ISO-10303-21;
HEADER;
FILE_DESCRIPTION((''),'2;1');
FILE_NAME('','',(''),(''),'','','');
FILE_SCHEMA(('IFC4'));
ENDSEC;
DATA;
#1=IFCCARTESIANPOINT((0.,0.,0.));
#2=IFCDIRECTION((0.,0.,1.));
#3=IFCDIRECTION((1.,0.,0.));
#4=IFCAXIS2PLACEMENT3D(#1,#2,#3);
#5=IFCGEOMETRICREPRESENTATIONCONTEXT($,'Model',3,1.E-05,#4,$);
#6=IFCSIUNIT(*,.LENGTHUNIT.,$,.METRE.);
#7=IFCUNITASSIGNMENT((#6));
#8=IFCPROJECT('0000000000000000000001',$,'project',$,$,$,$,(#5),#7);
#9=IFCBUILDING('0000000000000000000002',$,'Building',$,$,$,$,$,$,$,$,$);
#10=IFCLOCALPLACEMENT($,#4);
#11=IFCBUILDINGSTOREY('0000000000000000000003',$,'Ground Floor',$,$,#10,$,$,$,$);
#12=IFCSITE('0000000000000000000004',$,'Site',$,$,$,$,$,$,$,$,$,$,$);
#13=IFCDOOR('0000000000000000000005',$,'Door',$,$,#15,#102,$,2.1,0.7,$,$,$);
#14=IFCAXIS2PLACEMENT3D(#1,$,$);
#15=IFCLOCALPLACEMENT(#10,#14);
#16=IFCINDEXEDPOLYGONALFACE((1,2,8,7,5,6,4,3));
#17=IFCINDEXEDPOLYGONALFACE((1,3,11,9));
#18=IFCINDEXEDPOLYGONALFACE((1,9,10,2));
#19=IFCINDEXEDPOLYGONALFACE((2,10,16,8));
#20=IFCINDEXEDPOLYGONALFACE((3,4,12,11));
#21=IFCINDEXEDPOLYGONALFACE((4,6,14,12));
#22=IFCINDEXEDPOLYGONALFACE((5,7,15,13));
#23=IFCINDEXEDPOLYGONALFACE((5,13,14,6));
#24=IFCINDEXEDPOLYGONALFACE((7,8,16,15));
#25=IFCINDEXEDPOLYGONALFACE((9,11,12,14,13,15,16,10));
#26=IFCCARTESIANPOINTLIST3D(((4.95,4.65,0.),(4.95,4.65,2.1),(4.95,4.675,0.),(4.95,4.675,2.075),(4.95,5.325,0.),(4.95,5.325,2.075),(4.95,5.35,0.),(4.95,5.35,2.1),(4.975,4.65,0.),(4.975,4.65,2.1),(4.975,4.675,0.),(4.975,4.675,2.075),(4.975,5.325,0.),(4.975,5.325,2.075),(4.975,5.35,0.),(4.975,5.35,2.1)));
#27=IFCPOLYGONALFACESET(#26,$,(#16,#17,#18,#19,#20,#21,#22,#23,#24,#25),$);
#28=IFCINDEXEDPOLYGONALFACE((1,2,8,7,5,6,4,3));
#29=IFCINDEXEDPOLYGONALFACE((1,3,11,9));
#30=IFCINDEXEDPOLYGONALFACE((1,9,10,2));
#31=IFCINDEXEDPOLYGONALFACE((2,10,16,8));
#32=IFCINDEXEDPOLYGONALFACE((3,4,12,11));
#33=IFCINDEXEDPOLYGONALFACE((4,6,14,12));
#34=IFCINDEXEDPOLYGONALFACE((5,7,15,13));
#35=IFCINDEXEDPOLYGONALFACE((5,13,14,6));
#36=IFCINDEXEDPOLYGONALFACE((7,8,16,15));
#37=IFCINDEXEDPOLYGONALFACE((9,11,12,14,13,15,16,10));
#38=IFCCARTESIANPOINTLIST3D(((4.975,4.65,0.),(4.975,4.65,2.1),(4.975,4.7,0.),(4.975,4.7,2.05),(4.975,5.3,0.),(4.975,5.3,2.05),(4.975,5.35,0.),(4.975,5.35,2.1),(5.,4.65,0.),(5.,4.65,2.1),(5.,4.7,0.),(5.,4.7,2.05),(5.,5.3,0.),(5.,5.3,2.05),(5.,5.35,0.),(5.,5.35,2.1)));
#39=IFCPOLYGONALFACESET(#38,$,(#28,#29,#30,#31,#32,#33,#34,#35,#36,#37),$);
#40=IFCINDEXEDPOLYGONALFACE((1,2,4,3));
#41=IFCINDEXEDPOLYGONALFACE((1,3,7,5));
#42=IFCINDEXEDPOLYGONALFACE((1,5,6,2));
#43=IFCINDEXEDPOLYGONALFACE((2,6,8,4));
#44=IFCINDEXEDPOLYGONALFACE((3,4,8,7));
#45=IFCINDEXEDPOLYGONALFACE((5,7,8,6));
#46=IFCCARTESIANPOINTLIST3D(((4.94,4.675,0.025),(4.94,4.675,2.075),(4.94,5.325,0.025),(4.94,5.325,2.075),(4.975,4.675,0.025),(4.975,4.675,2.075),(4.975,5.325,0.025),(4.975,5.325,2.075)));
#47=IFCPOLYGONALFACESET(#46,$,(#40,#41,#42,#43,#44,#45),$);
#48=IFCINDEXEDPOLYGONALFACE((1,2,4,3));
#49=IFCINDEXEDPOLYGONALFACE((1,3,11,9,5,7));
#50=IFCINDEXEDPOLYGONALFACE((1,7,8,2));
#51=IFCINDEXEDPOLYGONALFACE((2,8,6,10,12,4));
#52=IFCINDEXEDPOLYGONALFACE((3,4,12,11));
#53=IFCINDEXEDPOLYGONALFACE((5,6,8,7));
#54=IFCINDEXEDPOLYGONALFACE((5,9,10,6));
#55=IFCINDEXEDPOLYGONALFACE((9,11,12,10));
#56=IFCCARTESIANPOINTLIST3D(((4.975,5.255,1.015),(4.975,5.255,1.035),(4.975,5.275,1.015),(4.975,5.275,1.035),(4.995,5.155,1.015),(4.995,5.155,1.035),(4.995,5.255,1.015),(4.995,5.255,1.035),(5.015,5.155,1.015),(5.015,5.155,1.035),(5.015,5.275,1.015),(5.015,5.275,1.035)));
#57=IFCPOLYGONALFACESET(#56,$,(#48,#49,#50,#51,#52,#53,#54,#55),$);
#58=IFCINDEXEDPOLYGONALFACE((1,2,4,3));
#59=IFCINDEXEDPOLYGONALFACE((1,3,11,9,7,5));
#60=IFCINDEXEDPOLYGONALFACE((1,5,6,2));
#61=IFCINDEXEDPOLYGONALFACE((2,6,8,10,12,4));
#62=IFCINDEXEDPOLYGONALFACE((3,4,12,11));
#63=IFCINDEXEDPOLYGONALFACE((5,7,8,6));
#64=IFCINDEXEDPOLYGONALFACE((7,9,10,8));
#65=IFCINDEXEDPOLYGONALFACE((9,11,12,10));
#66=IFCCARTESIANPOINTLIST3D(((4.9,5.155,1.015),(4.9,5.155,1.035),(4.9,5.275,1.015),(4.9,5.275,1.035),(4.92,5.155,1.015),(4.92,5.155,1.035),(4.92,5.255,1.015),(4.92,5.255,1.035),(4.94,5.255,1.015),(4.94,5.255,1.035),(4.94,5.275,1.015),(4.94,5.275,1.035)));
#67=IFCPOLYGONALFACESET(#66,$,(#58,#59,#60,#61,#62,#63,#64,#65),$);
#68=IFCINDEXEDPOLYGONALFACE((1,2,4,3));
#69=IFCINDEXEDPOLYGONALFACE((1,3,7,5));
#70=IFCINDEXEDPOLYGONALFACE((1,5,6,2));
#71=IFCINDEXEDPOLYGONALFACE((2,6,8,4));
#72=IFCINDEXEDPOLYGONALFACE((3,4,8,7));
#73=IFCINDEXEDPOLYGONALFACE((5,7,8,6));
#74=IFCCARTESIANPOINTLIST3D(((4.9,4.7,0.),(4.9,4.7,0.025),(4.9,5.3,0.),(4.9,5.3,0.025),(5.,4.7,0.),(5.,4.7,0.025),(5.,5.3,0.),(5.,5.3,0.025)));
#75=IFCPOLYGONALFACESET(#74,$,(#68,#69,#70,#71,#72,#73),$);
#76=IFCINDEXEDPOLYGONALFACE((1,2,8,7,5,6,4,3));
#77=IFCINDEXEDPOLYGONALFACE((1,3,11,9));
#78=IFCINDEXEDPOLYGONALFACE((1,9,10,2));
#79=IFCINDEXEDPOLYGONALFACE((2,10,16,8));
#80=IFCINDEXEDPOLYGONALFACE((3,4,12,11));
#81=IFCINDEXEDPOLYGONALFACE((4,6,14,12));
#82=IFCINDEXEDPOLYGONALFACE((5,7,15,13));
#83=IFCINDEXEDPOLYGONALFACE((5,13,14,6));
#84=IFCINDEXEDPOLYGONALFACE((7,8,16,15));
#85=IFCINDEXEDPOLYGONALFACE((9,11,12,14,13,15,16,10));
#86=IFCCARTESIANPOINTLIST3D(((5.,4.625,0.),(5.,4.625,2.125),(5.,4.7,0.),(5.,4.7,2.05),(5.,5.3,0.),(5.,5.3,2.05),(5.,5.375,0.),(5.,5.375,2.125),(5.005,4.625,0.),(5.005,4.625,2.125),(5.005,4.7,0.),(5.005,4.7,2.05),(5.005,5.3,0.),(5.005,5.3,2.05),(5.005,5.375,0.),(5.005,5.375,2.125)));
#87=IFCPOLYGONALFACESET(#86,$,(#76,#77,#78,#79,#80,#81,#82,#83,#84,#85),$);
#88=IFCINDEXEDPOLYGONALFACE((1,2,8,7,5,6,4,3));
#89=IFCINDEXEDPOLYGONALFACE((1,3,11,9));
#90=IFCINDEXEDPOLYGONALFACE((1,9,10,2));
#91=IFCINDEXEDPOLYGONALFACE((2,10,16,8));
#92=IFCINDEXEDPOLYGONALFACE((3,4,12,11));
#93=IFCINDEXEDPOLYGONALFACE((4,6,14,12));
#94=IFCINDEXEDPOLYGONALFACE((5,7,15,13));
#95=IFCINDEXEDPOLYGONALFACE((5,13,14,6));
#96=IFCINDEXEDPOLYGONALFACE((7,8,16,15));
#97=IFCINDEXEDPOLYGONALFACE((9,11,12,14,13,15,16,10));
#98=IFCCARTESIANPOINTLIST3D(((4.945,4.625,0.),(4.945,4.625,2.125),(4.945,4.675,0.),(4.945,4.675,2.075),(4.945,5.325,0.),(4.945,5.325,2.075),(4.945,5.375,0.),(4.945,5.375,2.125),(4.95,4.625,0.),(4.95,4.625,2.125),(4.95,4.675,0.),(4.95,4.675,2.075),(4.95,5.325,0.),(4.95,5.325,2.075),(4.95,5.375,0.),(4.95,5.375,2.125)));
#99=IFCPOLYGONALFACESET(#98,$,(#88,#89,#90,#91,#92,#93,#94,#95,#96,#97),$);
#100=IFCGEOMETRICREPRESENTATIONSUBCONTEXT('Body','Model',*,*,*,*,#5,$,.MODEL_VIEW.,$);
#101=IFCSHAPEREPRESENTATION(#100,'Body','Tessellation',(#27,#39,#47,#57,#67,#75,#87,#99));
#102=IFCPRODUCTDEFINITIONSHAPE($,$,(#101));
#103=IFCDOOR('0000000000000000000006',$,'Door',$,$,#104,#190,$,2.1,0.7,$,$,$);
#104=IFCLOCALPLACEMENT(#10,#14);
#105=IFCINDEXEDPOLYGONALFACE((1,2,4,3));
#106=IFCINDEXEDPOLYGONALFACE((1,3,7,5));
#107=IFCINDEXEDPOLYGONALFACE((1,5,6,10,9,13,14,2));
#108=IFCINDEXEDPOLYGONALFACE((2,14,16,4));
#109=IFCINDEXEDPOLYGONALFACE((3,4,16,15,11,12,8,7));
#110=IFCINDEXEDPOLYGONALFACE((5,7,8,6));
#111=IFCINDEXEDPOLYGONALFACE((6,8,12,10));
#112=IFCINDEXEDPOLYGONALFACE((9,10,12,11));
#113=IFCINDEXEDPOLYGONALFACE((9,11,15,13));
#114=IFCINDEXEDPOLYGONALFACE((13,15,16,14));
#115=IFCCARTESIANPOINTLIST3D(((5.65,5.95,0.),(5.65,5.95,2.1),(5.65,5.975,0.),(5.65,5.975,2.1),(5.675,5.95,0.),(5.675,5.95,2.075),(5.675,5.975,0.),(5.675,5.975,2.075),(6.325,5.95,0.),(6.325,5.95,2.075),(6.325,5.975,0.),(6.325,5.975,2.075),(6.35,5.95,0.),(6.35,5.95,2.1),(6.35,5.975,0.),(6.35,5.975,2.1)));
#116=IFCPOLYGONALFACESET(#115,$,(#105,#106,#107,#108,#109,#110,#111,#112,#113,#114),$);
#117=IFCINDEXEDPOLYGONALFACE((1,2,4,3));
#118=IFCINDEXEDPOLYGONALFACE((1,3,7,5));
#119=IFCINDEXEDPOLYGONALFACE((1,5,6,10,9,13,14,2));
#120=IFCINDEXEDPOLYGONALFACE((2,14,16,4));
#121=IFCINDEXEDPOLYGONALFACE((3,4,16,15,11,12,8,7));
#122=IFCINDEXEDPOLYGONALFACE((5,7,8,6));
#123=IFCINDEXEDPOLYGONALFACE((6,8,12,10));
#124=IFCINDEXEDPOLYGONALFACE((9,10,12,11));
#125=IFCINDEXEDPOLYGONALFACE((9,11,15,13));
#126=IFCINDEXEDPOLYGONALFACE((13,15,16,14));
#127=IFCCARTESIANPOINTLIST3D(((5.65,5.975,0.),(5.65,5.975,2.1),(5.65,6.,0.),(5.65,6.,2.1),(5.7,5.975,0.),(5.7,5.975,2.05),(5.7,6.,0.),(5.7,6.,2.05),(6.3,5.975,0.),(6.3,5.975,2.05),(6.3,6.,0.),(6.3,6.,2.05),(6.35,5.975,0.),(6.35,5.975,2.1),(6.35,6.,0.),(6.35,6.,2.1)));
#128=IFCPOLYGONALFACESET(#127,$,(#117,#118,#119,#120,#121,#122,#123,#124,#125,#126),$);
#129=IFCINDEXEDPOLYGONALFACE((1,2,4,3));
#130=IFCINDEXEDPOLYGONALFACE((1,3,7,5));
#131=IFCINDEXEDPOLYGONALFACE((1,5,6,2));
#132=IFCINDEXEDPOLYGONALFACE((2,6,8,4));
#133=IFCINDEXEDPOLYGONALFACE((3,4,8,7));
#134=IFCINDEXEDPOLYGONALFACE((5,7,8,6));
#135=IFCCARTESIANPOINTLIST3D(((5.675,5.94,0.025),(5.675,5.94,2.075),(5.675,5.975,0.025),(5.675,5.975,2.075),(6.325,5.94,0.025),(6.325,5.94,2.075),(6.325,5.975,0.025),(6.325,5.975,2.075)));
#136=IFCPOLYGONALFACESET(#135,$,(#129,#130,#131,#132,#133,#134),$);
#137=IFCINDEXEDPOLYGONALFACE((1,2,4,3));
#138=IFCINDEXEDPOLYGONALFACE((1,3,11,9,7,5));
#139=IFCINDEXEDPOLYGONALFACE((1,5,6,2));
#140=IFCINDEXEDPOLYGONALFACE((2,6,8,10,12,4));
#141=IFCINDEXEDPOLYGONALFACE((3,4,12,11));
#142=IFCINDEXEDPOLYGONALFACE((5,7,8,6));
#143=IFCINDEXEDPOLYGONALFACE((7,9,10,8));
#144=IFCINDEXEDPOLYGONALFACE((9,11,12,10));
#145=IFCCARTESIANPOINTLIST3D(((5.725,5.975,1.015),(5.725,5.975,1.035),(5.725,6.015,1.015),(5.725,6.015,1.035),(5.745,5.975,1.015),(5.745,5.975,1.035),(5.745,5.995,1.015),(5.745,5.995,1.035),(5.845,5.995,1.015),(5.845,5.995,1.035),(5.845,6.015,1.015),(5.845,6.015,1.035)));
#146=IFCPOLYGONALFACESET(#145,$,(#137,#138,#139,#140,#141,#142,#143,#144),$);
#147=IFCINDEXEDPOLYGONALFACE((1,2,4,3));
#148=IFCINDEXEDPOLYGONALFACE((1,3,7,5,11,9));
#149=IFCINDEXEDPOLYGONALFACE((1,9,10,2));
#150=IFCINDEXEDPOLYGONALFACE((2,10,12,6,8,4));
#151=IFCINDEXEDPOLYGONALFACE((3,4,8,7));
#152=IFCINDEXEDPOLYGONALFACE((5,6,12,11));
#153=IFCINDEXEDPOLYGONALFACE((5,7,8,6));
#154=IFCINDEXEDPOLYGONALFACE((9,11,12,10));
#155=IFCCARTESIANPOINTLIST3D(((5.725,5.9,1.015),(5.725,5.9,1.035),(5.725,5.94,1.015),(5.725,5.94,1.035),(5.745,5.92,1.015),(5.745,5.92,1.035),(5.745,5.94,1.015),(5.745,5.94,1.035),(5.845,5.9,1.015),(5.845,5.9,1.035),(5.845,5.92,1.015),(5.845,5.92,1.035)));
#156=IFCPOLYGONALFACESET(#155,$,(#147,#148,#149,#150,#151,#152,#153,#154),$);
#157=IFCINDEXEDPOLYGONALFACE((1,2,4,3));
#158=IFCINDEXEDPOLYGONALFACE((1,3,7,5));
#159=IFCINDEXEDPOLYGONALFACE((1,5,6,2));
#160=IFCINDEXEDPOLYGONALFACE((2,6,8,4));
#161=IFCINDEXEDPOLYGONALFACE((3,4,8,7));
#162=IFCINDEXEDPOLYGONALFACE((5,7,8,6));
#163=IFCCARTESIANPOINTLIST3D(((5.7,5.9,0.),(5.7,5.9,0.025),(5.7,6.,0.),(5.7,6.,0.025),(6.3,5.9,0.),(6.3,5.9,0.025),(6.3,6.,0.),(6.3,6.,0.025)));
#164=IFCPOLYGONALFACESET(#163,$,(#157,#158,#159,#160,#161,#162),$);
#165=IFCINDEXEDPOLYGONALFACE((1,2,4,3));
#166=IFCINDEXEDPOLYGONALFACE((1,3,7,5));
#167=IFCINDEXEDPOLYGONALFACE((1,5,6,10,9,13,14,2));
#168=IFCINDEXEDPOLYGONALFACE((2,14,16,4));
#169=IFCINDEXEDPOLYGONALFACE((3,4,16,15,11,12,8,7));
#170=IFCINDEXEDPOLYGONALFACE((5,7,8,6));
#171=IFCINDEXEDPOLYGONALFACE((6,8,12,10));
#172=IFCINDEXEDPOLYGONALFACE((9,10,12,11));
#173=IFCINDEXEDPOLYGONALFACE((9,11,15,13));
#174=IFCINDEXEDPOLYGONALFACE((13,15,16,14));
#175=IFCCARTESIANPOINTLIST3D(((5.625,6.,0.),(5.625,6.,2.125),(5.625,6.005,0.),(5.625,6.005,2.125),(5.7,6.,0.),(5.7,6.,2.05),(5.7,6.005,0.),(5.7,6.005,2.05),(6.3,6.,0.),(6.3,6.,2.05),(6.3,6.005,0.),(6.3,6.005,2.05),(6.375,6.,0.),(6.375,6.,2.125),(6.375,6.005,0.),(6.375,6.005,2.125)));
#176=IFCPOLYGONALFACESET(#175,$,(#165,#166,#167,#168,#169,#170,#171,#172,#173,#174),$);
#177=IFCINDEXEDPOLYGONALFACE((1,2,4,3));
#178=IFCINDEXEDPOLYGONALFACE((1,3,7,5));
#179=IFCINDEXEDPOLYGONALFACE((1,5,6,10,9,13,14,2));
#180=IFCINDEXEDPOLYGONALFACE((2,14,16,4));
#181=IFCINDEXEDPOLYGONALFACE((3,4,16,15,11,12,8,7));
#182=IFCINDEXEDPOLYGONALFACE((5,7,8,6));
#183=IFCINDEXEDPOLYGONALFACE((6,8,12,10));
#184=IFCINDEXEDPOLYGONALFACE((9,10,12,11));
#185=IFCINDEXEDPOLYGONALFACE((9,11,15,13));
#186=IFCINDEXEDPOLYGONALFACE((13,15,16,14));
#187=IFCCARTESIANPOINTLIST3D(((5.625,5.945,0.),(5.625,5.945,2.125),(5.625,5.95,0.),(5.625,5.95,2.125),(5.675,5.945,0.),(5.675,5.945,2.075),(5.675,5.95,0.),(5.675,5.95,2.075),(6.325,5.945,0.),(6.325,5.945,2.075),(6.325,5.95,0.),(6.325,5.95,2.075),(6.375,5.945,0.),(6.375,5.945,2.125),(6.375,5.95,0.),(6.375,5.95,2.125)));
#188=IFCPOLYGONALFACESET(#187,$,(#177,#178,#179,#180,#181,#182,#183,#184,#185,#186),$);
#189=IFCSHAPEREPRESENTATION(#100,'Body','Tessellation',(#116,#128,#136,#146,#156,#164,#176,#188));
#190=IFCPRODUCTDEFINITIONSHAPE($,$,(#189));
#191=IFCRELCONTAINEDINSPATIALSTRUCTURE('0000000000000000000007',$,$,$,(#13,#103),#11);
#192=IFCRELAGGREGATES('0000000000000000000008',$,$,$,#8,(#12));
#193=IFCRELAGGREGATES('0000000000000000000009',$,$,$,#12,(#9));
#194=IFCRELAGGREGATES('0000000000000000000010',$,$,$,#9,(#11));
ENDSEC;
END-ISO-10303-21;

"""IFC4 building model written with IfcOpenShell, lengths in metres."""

from ifc_helpers import new_model, si_unit, frame, origin_with_axes, place, context, subcontext, project, spatial, line, indexed_curve, outline, extrude, element, save


model = new_model("IFC4")

# Units and contexts
model_context = context("Model", 3, precision=1e-05, world=origin_with_axes())
body_context = subcontext(model_context, "Body", "Model", "MODEL_VIEW")
ifc_project = project(units=[si_unit("LENGTHUNIT", "METRE")], contexts=[model_context])

# Site, building, storey
site = spatial("IfcSite", under=ifc_project, Name="Site")
building = spatial("IfcBuilding", under=site, Name="Building")
storey_placement = place(None, origin_with_axes())
storey = spatial("IfcBuildingStorey", under=building, at=storey_placement, Name="Ground Floor")

# Doors
door_1_placement = place(storey_placement, frame((5.0, 4.65, 0.0), z_axis=(0.0, 0.0, 1.0), x_axis=(0.0, 1.0, 0.0)))
element("IfcDoor", 1, at=door_1_placement, inside=storey, Name="Door", OverallHeight=2.1, OverallWidth=0.7, context=body_context, shape_type="SweptSolid", body=[
    extrude(outline(indexed_curve([(0.0, 0.0), (0.0, 2.1), (0.7, 2.1), (0.7, 0.0), (0.675, 0.0), (0.675, 2.075), (0.025, 2.075), (0.025, 0.0)], segments=[line(1, 2, 3, 4, 5, 6, 7, 8, 1)])), frame((0.0, 0.025, 0.0), z_axis=(0.0, -1.0, 0.0), x_axis=(1.0, 0.0, 0.0)), (0.0, 0.0, -1.0), 0.025),
    extrude(outline(indexed_curve([(0.0, 0.0), (0.0, 2.1), (0.7, 2.1), (0.7, 0.0), (0.65, 0.0), (0.65, 2.05), (0.05, 2.05), (0.05, 0.0)], segments=[line(1, 2, 3, 4, 5, 6, 7, 8, 1)])), frame((0.0, 0.0, 0.0), z_axis=(0.0, -1.0, 0.0), x_axis=(1.0, 0.0, 0.0)), (0.0, 0.0, -1.0), 0.025),
    extrude(outline(indexed_curve([(0.0, 0.0), (0.65, 0.0), (0.65, 0.035), (0.0, 0.035)], segments=[line(1, 2, 3, 4, 1)])), frame((0.025, 0.025, 0.025), z_axis=(0.0, 0.0, 1.0), x_axis=(1.0, 0.0, 0.0)), (0.0, 0.0, 1.0), 2.05),
    extrude(outline(indexed_curve([(0.0, 0.0), (0.0, -0.04), (-0.12, -0.04), (-0.12, -0.02), (-0.02, -0.02), (-0.02, 0.0)], segments=[line(1, 2, 3, 4, 5, 6, 1)])), frame((0.625, 0.025, 1.015), z_axis=(0.0, 0.0, 1.0), x_axis=(1.0, 0.0, 0.0)), (0.0, 0.0, 1.0), 0.02),
    extrude(outline(indexed_curve([(0.0, 0.0), (0.0, 0.04), (-0.12, 0.04), (-0.12, 0.02), (-0.02, 0.02), (-0.02, 0.0)], segments=[line(1, 2, 3, 4, 5, 6, 1)])), frame((0.625, 0.06, 1.015), z_axis=(0.0, 0.0, 1.0), x_axis=(1.0, 0.0, 0.0)), (0.0, 0.0, 1.0), 0.02),
    extrude(outline(indexed_curve([(0.0, 0.0), (0.6, 0.0), (0.6, 0.1), (0.0, 0.1)], segments=[line(1, 2, 3, 4, 1)])), frame((0.05, 0.0, 0.0), z_axis=(0.0, 0.0, 1.0), x_axis=(1.0, 0.0, 0.0)), (0.0, 0.0, 1.0), 0.025),
    extrude(outline(indexed_curve([(0.0, 0.0), (0.0, 2.125), (0.75, 2.125), (0.75, 0.0), (0.675, 0.0), (0.675, 2.05), (0.075, 2.05), (0.075, 0.0)], segments=[line(1, 2, 3, 4, 5, 6, 7, 8, 1)])), frame((-0.025, -0.005, 0.0), z_axis=(0.0, -1.0, 0.0), x_axis=(1.0, 0.0, 0.0)), (0.0, 0.0, -1.0), 0.005),
    extrude(outline(indexed_curve([(0.0, 0.0), (0.0, 2.125), (0.75, 2.125), (0.75, 0.0), (0.7, 0.0), (0.7, 2.075), (0.05, 2.075), (0.05, 0.0)], segments=[line(1, 2, 3, 4, 5, 6, 7, 8, 1)])), frame((-0.025, 0.05, 0.0), z_axis=(0.0, -1.0, 0.0), x_axis=(1.0, 0.0, 0.0)), (0.0, 0.0, -1.0), 0.005),
])
door_2_placement = place(storey_placement, frame((6.35, 6.0, 0.0), z_axis=(0.0, 0.0, 1.0), x_axis=(-1.0, 0.0, 0.0)))
element("IfcDoor", 2, at=door_2_placement, inside=storey, Name="Door", OverallHeight=2.1, OverallWidth=0.7, context=body_context, shape_type="SweptSolid", body=[
    extrude(outline(indexed_curve([(0.0, 0.0), (0.0, 2.1), (0.7, 2.1), (0.7, 0.0), (0.675, 0.0), (0.675, 2.075), (0.025, 2.075), (0.025, 0.0)], segments=[line(1, 2, 3, 4, 5, 6, 7, 8, 1)])), frame((0.0, 0.025, 0.0), z_axis=(0.0, -1.0, 0.0), x_axis=(1.0, 0.0, 0.0)), (0.0, 0.0, -1.0), 0.025),
    extrude(outline(indexed_curve([(0.0, 0.0), (0.0, 2.1), (0.7, 2.1), (0.7, 0.0), (0.65, 0.0), (0.65, 2.05), (0.05, 2.05), (0.05, 0.0)], segments=[line(1, 2, 3, 4, 5, 6, 7, 8, 1)])), frame((0.0, 0.0, 0.0), z_axis=(0.0, -1.0, 0.0), x_axis=(1.0, 0.0, 0.0)), (0.0, 0.0, -1.0), 0.025),
    extrude(outline(indexed_curve([(0.0, 0.0), (0.65, 0.0), (0.65, 0.035), (0.0, 0.035)], segments=[line(1, 2, 3, 4, 1)])), frame((0.025, 0.025, 0.025), z_axis=(0.0, 0.0, 1.0), x_axis=(1.0, 0.0, 0.0)), (0.0, 0.0, 1.0), 2.05),
    extrude(outline(indexed_curve([(0.0, 0.0), (0.0, -0.04), (-0.12, -0.04), (-0.12, -0.02), (-0.02, -0.02), (-0.02, 0.0)], segments=[line(1, 2, 3, 4, 5, 6, 1)])), frame((0.625, 0.025, 1.015), z_axis=(0.0, 0.0, 1.0), x_axis=(1.0, 0.0, 0.0)), (0.0, 0.0, 1.0), 0.02),
    extrude(outline(indexed_curve([(0.0, 0.0), (0.0, 0.04), (-0.12, 0.04), (-0.12, 0.02), (-0.02, 0.02), (-0.02, 0.0)], segments=[line(1, 2, 3, 4, 5, 6, 1)])), frame((0.625, 0.06, 1.015), z_axis=(0.0, 0.0, 1.0), x_axis=(1.0, 0.0, 0.0)), (0.0, 0.0, 1.0), 0.02),
    extrude(outline(indexed_curve([(0.0, 0.0), (0.6, 0.0), (0.6, 0.1), (0.0, 0.1)], segments=[line(1, 2, 3, 4, 1)])), frame((0.05, 0.0, 0.0), z_axis=(0.0, 0.0, 1.0), x_axis=(1.0, 0.0, 0.0)), (0.0, 0.0, 1.0), 0.025),
    extrude(outline(indexed_curve([(0.0, 0.0), (0.0, 2.125), (0.75, 2.125), (0.75, 0.0), (0.675, 0.0), (0.675, 2.05), (0.075, 2.05), (0.075, 0.0)], segments=[line(1, 2, 3, 4, 5, 6, 7, 8, 1)])), frame((-0.025, -0.005, 0.0), z_axis=(0.0, -1.0, 0.0), x_axis=(1.0, 0.0, 0.0)), (0.0, 0.0, -1.0), 0.005),
    extrude(outline(indexed_curve([(0.0, 0.0), (0.0, 2.125), (0.75, 2.125), (0.75, 0.0), (0.7, 0.0), (0.7, 2.075), (0.05, 2.075), (0.05, 0.0)], segments=[line(1, 2, 3, 4, 5, 6, 7, 8, 1)])), frame((-0.025, 0.05, 0.0), z_axis=(0.0, -1.0, 0.0), x_axis=(1.0, 0.0, 0.0)), (0.0, 0.0, -1.0), 0.005),
])

save(model, "model.ifc")
